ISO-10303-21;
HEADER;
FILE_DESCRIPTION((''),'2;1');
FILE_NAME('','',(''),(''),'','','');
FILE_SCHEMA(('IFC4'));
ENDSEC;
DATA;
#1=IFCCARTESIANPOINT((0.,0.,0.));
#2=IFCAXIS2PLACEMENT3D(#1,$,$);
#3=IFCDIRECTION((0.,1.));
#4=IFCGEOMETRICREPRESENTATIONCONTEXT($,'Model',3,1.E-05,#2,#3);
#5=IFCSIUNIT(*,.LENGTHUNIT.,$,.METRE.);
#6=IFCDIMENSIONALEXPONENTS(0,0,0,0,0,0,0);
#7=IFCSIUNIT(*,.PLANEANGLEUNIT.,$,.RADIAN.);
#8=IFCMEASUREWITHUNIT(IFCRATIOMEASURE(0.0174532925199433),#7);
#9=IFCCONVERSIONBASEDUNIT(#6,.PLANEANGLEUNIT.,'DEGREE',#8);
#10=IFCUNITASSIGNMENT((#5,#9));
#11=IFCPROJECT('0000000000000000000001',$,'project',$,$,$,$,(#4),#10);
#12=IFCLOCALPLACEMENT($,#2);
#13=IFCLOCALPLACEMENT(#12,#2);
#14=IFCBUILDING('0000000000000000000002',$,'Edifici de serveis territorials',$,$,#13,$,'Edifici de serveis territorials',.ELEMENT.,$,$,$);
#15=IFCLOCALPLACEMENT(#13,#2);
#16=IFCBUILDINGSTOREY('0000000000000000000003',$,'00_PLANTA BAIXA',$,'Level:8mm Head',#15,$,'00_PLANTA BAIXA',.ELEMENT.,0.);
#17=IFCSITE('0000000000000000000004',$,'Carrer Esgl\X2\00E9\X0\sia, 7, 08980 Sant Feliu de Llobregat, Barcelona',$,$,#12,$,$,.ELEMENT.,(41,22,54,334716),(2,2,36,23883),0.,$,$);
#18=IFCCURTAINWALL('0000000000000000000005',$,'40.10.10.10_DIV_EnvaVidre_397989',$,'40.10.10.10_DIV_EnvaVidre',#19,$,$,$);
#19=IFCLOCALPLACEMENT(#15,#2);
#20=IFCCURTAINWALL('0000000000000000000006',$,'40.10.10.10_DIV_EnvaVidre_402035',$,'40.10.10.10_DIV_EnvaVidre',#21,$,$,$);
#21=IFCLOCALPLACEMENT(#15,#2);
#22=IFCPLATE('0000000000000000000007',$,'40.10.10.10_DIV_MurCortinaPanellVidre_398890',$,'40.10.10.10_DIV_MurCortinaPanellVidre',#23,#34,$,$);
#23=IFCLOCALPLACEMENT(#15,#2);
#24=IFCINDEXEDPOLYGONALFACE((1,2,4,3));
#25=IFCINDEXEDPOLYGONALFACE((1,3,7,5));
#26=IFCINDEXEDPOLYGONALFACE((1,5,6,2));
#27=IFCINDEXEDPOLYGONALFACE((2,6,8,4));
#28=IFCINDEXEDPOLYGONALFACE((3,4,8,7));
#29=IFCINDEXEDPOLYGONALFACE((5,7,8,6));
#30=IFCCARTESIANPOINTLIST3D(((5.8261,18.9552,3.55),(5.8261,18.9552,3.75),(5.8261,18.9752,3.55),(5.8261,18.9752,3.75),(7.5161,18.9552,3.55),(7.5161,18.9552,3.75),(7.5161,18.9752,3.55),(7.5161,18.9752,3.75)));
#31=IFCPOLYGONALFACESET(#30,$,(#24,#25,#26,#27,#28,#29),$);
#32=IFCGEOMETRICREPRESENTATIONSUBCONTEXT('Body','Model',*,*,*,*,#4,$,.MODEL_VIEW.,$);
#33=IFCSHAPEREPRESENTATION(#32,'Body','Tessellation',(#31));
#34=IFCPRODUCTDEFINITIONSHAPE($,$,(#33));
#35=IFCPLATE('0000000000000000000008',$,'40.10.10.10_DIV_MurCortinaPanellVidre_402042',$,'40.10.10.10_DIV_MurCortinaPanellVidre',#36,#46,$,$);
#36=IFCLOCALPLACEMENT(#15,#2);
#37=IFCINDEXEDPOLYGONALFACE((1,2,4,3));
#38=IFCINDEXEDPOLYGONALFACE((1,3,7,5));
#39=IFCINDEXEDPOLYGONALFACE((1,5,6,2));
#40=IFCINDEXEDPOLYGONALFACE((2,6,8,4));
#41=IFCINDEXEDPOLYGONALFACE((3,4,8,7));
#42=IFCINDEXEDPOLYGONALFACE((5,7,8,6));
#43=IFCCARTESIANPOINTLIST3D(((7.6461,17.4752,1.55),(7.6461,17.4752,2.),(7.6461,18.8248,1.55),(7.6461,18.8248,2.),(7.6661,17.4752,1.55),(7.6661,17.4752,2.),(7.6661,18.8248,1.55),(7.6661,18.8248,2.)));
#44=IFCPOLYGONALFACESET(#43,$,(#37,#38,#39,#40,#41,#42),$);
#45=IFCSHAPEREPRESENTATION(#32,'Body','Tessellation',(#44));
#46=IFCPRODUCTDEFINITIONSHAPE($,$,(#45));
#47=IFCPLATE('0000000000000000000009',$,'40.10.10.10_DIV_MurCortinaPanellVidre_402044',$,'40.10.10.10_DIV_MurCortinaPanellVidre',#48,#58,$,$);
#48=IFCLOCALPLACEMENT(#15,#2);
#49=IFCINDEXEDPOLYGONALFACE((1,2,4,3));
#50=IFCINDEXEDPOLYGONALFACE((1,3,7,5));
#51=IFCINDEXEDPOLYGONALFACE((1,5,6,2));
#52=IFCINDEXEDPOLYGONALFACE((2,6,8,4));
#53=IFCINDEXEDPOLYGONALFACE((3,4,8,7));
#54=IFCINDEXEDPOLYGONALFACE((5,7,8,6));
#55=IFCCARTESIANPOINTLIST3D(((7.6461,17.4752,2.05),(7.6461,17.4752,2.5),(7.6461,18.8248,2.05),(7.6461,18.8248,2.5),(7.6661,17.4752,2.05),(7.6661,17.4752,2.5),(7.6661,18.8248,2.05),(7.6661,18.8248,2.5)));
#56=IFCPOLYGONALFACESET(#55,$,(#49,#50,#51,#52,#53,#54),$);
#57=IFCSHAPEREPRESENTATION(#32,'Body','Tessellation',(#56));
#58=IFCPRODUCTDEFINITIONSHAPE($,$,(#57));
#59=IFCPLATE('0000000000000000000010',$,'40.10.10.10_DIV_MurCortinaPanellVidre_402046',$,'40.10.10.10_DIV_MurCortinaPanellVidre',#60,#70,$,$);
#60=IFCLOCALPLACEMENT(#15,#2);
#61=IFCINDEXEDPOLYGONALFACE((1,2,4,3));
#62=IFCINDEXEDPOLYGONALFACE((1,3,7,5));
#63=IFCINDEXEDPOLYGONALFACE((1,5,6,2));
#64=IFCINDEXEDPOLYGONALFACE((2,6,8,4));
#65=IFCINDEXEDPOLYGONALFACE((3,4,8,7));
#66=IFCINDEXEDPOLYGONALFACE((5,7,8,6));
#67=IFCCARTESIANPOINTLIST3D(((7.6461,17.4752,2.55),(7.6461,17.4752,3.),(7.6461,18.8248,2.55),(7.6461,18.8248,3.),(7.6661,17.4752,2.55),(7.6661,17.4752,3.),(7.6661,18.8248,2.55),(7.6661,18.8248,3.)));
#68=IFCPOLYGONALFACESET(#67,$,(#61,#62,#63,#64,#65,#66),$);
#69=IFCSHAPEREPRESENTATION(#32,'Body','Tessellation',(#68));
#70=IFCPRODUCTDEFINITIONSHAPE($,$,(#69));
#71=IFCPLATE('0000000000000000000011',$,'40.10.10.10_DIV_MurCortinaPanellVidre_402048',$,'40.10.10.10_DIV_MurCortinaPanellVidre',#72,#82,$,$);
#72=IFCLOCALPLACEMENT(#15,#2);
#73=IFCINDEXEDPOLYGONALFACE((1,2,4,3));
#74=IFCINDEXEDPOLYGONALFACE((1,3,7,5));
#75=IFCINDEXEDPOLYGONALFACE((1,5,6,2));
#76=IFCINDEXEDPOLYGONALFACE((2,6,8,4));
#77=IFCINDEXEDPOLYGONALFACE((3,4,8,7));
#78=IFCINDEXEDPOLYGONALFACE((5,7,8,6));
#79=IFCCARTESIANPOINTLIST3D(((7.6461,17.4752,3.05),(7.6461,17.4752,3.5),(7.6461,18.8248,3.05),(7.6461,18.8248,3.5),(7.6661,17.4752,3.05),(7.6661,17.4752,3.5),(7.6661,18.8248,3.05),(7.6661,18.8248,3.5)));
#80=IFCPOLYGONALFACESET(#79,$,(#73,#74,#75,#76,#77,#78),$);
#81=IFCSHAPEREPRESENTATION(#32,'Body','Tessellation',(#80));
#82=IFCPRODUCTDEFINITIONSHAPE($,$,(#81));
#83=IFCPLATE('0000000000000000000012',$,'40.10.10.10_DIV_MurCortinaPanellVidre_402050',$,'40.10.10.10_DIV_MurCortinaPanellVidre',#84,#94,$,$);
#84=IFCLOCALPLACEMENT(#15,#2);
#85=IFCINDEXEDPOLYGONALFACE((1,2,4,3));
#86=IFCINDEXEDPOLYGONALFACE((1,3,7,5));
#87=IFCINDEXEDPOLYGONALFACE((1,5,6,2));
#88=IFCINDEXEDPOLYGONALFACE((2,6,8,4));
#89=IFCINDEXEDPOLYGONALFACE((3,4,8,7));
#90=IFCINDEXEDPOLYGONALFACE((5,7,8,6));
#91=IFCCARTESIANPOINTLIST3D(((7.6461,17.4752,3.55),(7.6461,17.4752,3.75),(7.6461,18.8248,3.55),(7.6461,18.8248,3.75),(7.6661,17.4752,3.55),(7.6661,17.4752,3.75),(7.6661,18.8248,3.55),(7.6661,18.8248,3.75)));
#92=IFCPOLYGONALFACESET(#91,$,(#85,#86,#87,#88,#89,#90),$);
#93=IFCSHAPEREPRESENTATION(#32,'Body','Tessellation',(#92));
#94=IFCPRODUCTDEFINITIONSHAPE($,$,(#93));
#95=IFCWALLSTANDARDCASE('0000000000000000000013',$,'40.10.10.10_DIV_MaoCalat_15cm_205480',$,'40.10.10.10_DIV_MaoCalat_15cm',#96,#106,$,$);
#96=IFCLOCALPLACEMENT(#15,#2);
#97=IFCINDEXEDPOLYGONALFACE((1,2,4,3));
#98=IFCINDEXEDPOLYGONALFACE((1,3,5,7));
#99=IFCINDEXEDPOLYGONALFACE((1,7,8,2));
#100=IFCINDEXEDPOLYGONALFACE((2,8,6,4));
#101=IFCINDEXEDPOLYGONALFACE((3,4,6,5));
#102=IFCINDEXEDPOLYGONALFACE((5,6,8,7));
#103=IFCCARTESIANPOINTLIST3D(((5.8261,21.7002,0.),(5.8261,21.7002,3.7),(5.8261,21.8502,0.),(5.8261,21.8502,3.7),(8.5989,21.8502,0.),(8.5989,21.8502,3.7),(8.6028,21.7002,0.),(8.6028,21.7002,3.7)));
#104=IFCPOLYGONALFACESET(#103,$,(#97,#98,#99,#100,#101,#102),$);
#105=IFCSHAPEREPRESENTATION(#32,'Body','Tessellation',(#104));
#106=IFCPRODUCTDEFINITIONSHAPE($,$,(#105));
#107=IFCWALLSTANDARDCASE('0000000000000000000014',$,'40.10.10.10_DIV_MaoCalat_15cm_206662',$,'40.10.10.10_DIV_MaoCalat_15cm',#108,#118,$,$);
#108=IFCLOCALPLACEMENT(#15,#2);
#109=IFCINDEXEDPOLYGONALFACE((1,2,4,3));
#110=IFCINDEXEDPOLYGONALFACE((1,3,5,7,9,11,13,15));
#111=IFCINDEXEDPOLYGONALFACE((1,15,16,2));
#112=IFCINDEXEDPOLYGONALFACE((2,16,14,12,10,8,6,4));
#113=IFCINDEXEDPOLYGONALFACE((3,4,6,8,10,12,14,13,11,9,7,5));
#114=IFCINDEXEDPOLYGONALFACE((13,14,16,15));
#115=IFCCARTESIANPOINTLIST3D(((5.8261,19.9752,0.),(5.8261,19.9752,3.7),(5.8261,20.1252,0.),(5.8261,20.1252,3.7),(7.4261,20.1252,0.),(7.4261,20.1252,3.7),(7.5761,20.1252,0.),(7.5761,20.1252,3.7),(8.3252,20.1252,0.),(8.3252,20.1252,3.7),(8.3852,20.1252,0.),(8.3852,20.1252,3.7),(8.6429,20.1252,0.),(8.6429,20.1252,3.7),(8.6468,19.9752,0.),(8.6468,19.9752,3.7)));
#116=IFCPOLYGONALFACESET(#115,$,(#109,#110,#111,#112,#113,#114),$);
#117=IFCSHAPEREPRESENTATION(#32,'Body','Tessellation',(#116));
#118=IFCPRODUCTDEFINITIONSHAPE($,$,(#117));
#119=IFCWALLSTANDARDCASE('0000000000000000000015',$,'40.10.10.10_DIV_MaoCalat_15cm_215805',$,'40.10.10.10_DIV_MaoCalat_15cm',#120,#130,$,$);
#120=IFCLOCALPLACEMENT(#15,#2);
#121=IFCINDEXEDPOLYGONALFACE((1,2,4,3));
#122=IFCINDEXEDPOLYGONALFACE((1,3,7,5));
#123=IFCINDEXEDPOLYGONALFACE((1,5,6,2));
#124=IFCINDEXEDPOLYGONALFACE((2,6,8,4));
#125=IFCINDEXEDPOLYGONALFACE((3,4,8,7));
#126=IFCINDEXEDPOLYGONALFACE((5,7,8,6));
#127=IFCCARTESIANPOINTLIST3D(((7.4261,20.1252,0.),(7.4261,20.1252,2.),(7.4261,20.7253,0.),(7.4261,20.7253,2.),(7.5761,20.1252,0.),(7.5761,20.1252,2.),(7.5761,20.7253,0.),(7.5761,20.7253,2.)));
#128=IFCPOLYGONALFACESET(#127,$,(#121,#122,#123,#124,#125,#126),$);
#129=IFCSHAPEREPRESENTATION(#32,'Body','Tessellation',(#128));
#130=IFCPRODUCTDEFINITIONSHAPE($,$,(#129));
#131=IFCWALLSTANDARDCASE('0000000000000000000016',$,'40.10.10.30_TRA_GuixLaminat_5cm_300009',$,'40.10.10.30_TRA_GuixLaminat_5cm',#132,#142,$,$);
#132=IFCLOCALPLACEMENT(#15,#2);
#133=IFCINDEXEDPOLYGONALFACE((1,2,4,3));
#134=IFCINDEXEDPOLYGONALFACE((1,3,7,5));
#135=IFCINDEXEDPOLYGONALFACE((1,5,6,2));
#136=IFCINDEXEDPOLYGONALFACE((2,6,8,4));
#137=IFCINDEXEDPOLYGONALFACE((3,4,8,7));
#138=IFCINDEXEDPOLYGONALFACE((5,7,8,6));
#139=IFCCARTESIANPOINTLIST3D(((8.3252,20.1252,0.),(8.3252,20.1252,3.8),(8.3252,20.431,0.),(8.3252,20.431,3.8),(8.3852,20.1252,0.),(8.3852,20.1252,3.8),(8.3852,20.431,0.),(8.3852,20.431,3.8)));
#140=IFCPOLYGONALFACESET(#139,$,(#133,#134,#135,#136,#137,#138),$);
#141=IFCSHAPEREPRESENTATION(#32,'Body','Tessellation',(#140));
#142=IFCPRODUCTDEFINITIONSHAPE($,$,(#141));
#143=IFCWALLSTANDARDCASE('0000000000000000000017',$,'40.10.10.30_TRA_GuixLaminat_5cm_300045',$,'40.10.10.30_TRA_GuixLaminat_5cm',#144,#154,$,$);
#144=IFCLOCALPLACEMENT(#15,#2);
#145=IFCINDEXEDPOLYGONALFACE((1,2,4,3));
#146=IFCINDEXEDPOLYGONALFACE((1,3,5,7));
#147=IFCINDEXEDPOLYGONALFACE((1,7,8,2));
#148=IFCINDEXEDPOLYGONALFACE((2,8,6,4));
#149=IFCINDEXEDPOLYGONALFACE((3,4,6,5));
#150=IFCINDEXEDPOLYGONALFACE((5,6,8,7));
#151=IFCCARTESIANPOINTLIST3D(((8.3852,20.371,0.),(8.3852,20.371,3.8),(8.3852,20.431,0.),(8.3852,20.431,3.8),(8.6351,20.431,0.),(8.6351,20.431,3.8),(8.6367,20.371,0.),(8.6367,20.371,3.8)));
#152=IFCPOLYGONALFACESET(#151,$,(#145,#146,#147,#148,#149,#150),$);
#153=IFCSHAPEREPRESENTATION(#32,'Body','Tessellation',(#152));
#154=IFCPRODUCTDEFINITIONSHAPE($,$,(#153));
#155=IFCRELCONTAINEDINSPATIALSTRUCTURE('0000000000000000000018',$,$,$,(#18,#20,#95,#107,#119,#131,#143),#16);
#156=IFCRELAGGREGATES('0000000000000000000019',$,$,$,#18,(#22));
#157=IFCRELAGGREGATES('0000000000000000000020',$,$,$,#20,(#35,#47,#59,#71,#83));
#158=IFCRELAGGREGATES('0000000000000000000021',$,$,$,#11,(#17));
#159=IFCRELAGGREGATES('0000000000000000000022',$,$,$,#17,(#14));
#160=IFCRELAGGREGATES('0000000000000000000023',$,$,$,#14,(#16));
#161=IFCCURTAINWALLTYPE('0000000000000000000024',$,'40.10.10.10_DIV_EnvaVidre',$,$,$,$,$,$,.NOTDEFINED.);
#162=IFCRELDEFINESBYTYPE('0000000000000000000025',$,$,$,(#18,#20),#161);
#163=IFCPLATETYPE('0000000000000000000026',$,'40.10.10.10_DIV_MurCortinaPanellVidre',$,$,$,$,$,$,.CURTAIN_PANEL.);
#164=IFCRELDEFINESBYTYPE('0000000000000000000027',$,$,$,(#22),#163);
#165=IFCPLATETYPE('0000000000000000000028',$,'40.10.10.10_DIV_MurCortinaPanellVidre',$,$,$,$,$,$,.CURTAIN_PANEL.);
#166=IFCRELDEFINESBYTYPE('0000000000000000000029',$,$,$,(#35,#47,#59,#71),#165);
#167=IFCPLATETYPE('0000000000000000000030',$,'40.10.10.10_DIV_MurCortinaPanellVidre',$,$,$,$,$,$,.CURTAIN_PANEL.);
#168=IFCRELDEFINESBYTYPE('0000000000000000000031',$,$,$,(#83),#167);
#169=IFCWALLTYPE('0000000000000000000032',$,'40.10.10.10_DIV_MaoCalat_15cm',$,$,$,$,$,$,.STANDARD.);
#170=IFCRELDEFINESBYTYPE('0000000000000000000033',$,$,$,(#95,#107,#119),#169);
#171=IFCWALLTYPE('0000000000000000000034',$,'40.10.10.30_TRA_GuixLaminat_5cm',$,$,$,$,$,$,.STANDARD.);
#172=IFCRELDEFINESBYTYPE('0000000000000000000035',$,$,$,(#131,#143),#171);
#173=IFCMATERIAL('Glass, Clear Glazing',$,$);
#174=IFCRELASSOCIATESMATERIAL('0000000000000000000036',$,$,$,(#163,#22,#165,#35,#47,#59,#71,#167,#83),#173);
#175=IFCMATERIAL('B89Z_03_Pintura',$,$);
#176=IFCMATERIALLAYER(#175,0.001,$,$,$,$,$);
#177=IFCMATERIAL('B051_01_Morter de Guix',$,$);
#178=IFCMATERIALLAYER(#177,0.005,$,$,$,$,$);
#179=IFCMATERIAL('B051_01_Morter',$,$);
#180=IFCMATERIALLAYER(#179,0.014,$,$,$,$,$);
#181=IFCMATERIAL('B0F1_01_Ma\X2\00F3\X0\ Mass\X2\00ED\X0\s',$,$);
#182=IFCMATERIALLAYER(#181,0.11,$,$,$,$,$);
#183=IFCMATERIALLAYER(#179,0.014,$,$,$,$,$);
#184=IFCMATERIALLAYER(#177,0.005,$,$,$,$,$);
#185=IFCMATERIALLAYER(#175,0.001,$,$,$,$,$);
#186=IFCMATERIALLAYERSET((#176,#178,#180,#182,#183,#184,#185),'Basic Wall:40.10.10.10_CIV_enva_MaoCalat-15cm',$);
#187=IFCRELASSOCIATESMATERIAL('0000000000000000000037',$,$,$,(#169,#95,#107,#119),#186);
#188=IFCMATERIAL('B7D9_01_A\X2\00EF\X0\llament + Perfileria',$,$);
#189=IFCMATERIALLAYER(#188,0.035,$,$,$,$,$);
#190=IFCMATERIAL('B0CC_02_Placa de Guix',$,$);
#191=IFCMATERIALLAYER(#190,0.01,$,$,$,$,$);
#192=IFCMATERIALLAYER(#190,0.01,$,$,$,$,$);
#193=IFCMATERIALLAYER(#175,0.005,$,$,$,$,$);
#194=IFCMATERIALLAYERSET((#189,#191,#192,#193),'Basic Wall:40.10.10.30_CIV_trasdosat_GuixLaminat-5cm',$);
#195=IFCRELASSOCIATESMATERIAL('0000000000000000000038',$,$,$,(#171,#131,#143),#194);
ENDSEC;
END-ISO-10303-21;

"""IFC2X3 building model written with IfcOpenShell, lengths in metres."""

from ifc_helpers import new_model, entity, si_unit, converted_unit, direction, frame, frame_2d, origin, place, context, subcontext, project, spatial, polyline, rectangle, outline, extrude, source, transform, mapped, material, layer, layer_set, layer_usage, type_object, type_shapes, element, aggregate, save


model = new_model("IFC2X3")

# Units and contexts
model_context = context("Model", 3, precision=1e-05, world=origin(), true_north=direction((0.0, 1.0)))
body_context = subcontext(model_context, "Body", "Model", "MODEL_VIEW")
ifc_project = project(units=[si_unit("LENGTHUNIT", "METRE"), converted_unit("PLANEANGLEUNIT", "DEGREE", entity("IfcRatioMeasure", 0.0174532925199433), si_unit("PLANEANGLEUNIT", "RADIAN"), dimensions=[0, 0, 0, 0, 0, 0, 0])], contexts=[model_context])

# Site, building, storey
site_placement = place(None, origin())
site = spatial("IfcSite", under=ifc_project, at=site_placement, Name="Carrer Església, 7, 08980 Sant Feliu de Llobregat, Barcelona", CompositionType="ELEMENT", RefLatitude=(41, 22, 54, 334716), RefLongitude=(2, 2, 36, 23883), RefElevation=0.0)
building_placement = place(site_placement, origin())
building = spatial("IfcBuilding", under=site, at=building_placement, Name="Edifici de serveis territorials", LongName="Edifici de serveis territorials", CompositionType="ELEMENT")
storey_placement = place(building_placement, origin())
storey = spatial("IfcBuildingStorey", under=building, at=storey_placement, Name="00_PLANTA BAIXA", ObjectType="Level:8mm Head", LongName="00_PLANTA BAIXA", CompositionType="ELEMENT", Elevation=0.0)

# Curtain walls
curtain_wall_type = type_object("IfcCurtainWallType", Name="40.10.10.10_DIV_EnvaVidre", PredefinedType="NOTDEFINED")
curtain_wall_1_placement = place(storey_placement, origin())
curtain_wall_1 = element("IfcCurtainWall", 1, at=curtain_wall_1_placement, inside=storey, type_object=curtain_wall_type, Name="40.10.10.10_DIV_EnvaVidre_397989", ObjectType="40.10.10.10_DIV_EnvaVidre")
curtain_wall_2_placement = place(storey_placement, origin())
curtain_wall_2 = element("IfcCurtainWall", 2, at=curtain_wall_2_placement, inside=storey, type_object=curtain_wall_type, Name="40.10.10.10_DIV_EnvaVidre_402035", ObjectType="40.10.10.10_DIV_EnvaVidre")

# Plates
ifc_material_1 = material(Name="Glass, Clear Glazing")
plate_type_1 = type_object("IfcPlateType", Name="40.10.10.10_DIV_MurCortinaPanellVidre", PredefinedType="CURTAIN_PANEL", material=ifc_material_1)
shared_shape_1 = source(origin(), body_context, "Body", "SweptSolid", [
    extrude(rectangle(XDim=0.02, YDim=1.69, at=frame_2d((0.0, 0.0), x_axis=(1.0, 0.0))), frame((0.845, 0.01, 0.0), z_axis=(0.0, 0.0, 1.0), x_axis=(0.0, 1.0, 0.0)), (0.0, 0.0, 1.0), 0.2),
])
type_shapes(plate_type_1, [shared_shape_1])
plate_1_placement = place(curtain_wall_1_placement, frame((5.8261, 18.9552, 3.55)))
plate_1 = element("IfcPlate", 3, at=plate_1_placement, type_object=plate_type_1, material=ifc_material_1, Name="40.10.10.10_DIV_MurCortinaPanellVidre_398890", ObjectType="40.10.10.10_DIV_MurCortinaPanellVidre", context=body_context, shape_type="MappedRepresentation", body=[
    mapped(shared_shape_1, transform((0.0, 0.0, 0.0), scale=1.0)),
])
aggregate(curtain_wall_1, [plate_1])
plate_type_2 = type_object("IfcPlateType", Name="40.10.10.10_DIV_MurCortinaPanellVidre", PredefinedType="CURTAIN_PANEL", material=ifc_material_1)
shared_shape_2 = source(origin(), body_context, "Body", "SweptSolid", [
    extrude(rectangle(XDim=0.02, YDim=1.3496, at=frame_2d((0.0, 0.0), x_axis=(1.0, 0.0))), frame((0.6748, 0.01, 0.0), z_axis=(0.0, 0.0, 1.0), x_axis=(0.0, 1.0, 0.0)), (0.0, 0.0, 1.0), 0.45),
])
type_shapes(plate_type_2, [shared_shape_2])
plate_2_placement = place(curtain_wall_2_placement, frame((7.6461, 18.8248, 1.55), z_axis=(0.0, 0.0, 1.0), x_axis=(0.0, -1.0, 0.0)))
plate_2 = element("IfcPlate", 4, at=plate_2_placement, type_object=plate_type_2, material=ifc_material_1, Name="40.10.10.10_DIV_MurCortinaPanellVidre_402042", ObjectType="40.10.10.10_DIV_MurCortinaPanellVidre", context=body_context, shape_type="MappedRepresentation", body=[
    mapped(shared_shape_2, transform((0.0, 0.0, 0.0), scale=1.0)),
])
plate_3_placement = place(curtain_wall_2_placement, frame((7.6461, 18.8248, 2.05), z_axis=(0.0, 0.0, 1.0), x_axis=(0.0, -1.0, 0.0)))
plate_3 = element("IfcPlate", 5, at=plate_3_placement, type_object=plate_type_2, material=ifc_material_1, Name="40.10.10.10_DIV_MurCortinaPanellVidre_402044", ObjectType="40.10.10.10_DIV_MurCortinaPanellVidre", context=body_context, shape_type="MappedRepresentation", body=[
    mapped(shared_shape_2, transform((0.0, 0.0, 0.0), scale=1.0)),
])
plate_4_placement = place(curtain_wall_2_placement, frame((7.6461, 18.8248, 2.55), z_axis=(0.0, 0.0, 1.0), x_axis=(0.0, -1.0, 0.0)))
plate_4 = element("IfcPlate", 6, at=plate_4_placement, type_object=plate_type_2, material=ifc_material_1, Name="40.10.10.10_DIV_MurCortinaPanellVidre_402046", ObjectType="40.10.10.10_DIV_MurCortinaPanellVidre", context=body_context, shape_type="MappedRepresentation", body=[
    mapped(shared_shape_2, transform((0.0, 0.0, 0.0), scale=1.0)),
])
plate_5_placement = place(curtain_wall_2_placement, frame((7.6461, 18.8248, 3.05), z_axis=(0.0, 0.0, 1.0), x_axis=(0.0, -1.0, 0.0)))
plate_5 = element("IfcPlate", 7, at=plate_5_placement, type_object=plate_type_2, material=ifc_material_1, Name="40.10.10.10_DIV_MurCortinaPanellVidre_402048", ObjectType="40.10.10.10_DIV_MurCortinaPanellVidre", context=body_context, shape_type="MappedRepresentation", body=[
    mapped(shared_shape_2, transform((0.0, 0.0, 0.0), scale=1.0)),
])
plate_type_3 = type_object("IfcPlateType", Name="40.10.10.10_DIV_MurCortinaPanellVidre", PredefinedType="CURTAIN_PANEL", material=ifc_material_1)
shared_shape_3 = source(origin(), body_context, "Body", "SweptSolid", [
    extrude(rectangle(XDim=0.02, YDim=1.3496, at=frame_2d((0.0, 0.0), x_axis=(1.0, 0.0))), frame((0.6748, 0.01, 0.0), z_axis=(0.0, 0.0, 1.0), x_axis=(0.0, 1.0, 0.0)), (0.0, 0.0, 1.0), 0.2),
])
type_shapes(plate_type_3, [shared_shape_3])
plate_6_placement = place(curtain_wall_2_placement, frame((7.6461, 18.8248, 3.55), z_axis=(0.0, 0.0, 1.0), x_axis=(0.0, -1.0, 0.0)))
plate_6 = element("IfcPlate", 8, at=plate_6_placement, type_object=plate_type_3, material=ifc_material_1, Name="40.10.10.10_DIV_MurCortinaPanellVidre_402050", ObjectType="40.10.10.10_DIV_MurCortinaPanellVidre", context=body_context, shape_type="MappedRepresentation", body=[
    mapped(shared_shape_3, transform((0.0, 0.0, 0.0), scale=1.0)),
])
aggregate(curtain_wall_2, [plate_2, plate_3, plate_4, plate_5, plate_6])

# Walls
ifc_material_2 = material(Name="B89Z_03_Pintura")
ifc_layer_1 = layer(ifc_material_2, 0.001)
ifc_material_3 = material(Name="B051_01_Morter de Guix")
ifc_layer_2 = layer(ifc_material_3, 0.005)
ifc_material_4 = material(Name="B051_01_Morter")
ifc_layer_3 = layer(ifc_material_4, 0.014)
ifc_material_5 = material(Name="B0F1_01_Maó Massís")
ifc_layer_4 = layer(ifc_material_5, 0.11)
ifc_layer_5 = layer(ifc_material_4, 0.014)
ifc_layer_6 = layer(ifc_material_3, 0.005)
ifc_layer_7 = layer(ifc_material_2, 0.001)
ifc_layer_set_1 = layer_set([ifc_layer_1, ifc_layer_2, ifc_layer_3, ifc_layer_4, ifc_layer_5, ifc_layer_6, ifc_layer_7], Name="Basic Wall:40.10.10.10_CIV_enva_MaoCalat-15cm")
ifc_layer_usage_1 = layer_usage(ifc_layer_set_1, "AXIS2", "NEGATIVE", 0.075)
wall_type_1 = type_object("IfcWallType", Name="40.10.10.10_DIV_MaoCalat_15cm", PredefinedType="STANDARD", material=ifc_layer_set_1)
wall_1_placement = place(storey_placement, frame((8.6028, 21.7752, 0.0), z_axis=(0.0, 0.0, 1.0), x_axis=(-1.0, 0.0, 0.0)))
element("IfcWallStandardCase", 9, at=wall_1_placement, inside=storey, type_object=wall_type_1, material=ifc_layer_usage_1, Name="40.10.10.10_DIV_MaoCalat_15cm_205480", ObjectType="40.10.10.10_DIV_MaoCalat_15cm", context=body_context, shape_type="SweptSolid", body=[
    extrude(outline(polyline([(2.7767, -0.075), (2.7767, 0.075), (0.0, 0.075), (0.0038, -0.075), (2.7767, -0.075)])), origin(), (0.0, 0.0, 1.0), 3.7),
])
ifc_layer_usage_2 = layer_usage(ifc_layer_set_1, "AXIS2", "NEGATIVE", 0.075)
wall_2_placement = place(storey_placement, frame((5.8261, 20.0502, 0.0)))
element("IfcWallStandardCase", 10, at=wall_2_placement, inside=storey, type_object=wall_type_1, material=ifc_layer_usage_2, Name="40.10.10.10_DIV_MaoCalat_15cm_206662", ObjectType="40.10.10.10_DIV_MaoCalat_15cm", context=body_context, shape_type="SweptSolid", body=[
    extrude(outline(polyline([(2.8207, -0.075), (2.8168, 0.075), (2.5591, 0.075), (2.4991, 0.075), (1.75, 0.075), (1.6, 0.075), (0.0, 0.075), (0.0, -0.075), (2.8207, -0.075)])), origin(), (0.0, 0.0, 1.0), 3.7),
])
ifc_layer_usage_3 = layer_usage(ifc_layer_set_1, "AXIS2", "NEGATIVE", 0.075)
wall_3_placement = place(storey_placement, frame((7.5011, 20.1252, 0.0), z_axis=(0.0, 0.0, 1.0), x_axis=(0.0, 1.0, 0.0)))
element("IfcWallStandardCase", 11, at=wall_3_placement, inside=storey, type_object=wall_type_1, material=ifc_layer_usage_3, Name="40.10.10.10_DIV_MaoCalat_15cm_215805", ObjectType="40.10.10.10_DIV_MaoCalat_15cm", context=body_context, shape_type="SweptSolid", body=[
    extrude(rectangle(XDim=0.6001, YDim=0.15, at=frame_2d((0.3, 0.0), x_axis=(-1.0, 0.0))), origin(), (0.0, 0.0, 1.0), 2.0),
])
ifc_material_6 = material(Name="B7D9_01_Aïllament + Perfileria")
ifc_layer_8 = layer(ifc_material_6, 0.035)
ifc_material_7 = material(Name="B0CC_02_Placa de Guix")
ifc_layer_9 = layer(ifc_material_7, 0.01)
ifc_layer_10 = layer(ifc_material_7, 0.01)
ifc_layer_11 = layer(ifc_material_2, 0.005)
ifc_layer_set_2 = layer_set([ifc_layer_8, ifc_layer_9, ifc_layer_10, ifc_layer_11], Name="Basic Wall:40.10.10.30_CIV_trasdosat_GuixLaminat-5cm")
ifc_layer_usage_4 = layer_usage(ifc_layer_set_2, "AXIS2", "POSITIVE", -0.03)
wall_type_2 = type_object("IfcWallType", Name="40.10.10.30_TRA_GuixLaminat_5cm", PredefinedType="STANDARD", material=ifc_layer_set_2)
wall_4_placement = place(storey_placement, frame((8.3552, 20.1252, 0.0), z_axis=(0.0, 0.0, 1.0), x_axis=(0.0, 1.0, 0.0)))
element("IfcWallStandardCase", 12, at=wall_4_placement, inside=storey, type_object=wall_type_2, material=ifc_layer_usage_4, Name="40.10.10.30_TRA_GuixLaminat_5cm_300009", ObjectType="40.10.10.30_TRA_GuixLaminat_5cm", context=body_context, shape_type="SweptSolid", body=[
    extrude(rectangle(XDim=0.3058, YDim=0.06, at=frame_2d((0.1529, 0.0), x_axis=(-1.0, 0.0))), origin(), (0.0, 0.0, 1.0), 3.8),
])
ifc_layer_usage_5 = layer_usage(ifc_layer_set_2, "AXIS2", "POSITIVE", -0.03)
wall_5_placement = place(storey_placement, frame((8.3852, 20.401, 0.0)))
element("IfcWallStandardCase", 13, at=wall_5_placement, inside=storey, type_object=wall_type_2, material=ifc_layer_usage_5, Name="40.10.10.30_TRA_GuixLaminat_5cm_300045", ObjectType="40.10.10.30_TRA_GuixLaminat_5cm", context=body_context, shape_type="SweptSolid", body=[
    extrude(outline(polyline([(0.2515, -0.03), (0.25, 0.03), (0.0, 0.03), (0.0, -0.03), (0.2515, -0.03)])), origin(), (0.0, 0.0, 1.0), 3.8),
])

save(model, "model.ifc")
